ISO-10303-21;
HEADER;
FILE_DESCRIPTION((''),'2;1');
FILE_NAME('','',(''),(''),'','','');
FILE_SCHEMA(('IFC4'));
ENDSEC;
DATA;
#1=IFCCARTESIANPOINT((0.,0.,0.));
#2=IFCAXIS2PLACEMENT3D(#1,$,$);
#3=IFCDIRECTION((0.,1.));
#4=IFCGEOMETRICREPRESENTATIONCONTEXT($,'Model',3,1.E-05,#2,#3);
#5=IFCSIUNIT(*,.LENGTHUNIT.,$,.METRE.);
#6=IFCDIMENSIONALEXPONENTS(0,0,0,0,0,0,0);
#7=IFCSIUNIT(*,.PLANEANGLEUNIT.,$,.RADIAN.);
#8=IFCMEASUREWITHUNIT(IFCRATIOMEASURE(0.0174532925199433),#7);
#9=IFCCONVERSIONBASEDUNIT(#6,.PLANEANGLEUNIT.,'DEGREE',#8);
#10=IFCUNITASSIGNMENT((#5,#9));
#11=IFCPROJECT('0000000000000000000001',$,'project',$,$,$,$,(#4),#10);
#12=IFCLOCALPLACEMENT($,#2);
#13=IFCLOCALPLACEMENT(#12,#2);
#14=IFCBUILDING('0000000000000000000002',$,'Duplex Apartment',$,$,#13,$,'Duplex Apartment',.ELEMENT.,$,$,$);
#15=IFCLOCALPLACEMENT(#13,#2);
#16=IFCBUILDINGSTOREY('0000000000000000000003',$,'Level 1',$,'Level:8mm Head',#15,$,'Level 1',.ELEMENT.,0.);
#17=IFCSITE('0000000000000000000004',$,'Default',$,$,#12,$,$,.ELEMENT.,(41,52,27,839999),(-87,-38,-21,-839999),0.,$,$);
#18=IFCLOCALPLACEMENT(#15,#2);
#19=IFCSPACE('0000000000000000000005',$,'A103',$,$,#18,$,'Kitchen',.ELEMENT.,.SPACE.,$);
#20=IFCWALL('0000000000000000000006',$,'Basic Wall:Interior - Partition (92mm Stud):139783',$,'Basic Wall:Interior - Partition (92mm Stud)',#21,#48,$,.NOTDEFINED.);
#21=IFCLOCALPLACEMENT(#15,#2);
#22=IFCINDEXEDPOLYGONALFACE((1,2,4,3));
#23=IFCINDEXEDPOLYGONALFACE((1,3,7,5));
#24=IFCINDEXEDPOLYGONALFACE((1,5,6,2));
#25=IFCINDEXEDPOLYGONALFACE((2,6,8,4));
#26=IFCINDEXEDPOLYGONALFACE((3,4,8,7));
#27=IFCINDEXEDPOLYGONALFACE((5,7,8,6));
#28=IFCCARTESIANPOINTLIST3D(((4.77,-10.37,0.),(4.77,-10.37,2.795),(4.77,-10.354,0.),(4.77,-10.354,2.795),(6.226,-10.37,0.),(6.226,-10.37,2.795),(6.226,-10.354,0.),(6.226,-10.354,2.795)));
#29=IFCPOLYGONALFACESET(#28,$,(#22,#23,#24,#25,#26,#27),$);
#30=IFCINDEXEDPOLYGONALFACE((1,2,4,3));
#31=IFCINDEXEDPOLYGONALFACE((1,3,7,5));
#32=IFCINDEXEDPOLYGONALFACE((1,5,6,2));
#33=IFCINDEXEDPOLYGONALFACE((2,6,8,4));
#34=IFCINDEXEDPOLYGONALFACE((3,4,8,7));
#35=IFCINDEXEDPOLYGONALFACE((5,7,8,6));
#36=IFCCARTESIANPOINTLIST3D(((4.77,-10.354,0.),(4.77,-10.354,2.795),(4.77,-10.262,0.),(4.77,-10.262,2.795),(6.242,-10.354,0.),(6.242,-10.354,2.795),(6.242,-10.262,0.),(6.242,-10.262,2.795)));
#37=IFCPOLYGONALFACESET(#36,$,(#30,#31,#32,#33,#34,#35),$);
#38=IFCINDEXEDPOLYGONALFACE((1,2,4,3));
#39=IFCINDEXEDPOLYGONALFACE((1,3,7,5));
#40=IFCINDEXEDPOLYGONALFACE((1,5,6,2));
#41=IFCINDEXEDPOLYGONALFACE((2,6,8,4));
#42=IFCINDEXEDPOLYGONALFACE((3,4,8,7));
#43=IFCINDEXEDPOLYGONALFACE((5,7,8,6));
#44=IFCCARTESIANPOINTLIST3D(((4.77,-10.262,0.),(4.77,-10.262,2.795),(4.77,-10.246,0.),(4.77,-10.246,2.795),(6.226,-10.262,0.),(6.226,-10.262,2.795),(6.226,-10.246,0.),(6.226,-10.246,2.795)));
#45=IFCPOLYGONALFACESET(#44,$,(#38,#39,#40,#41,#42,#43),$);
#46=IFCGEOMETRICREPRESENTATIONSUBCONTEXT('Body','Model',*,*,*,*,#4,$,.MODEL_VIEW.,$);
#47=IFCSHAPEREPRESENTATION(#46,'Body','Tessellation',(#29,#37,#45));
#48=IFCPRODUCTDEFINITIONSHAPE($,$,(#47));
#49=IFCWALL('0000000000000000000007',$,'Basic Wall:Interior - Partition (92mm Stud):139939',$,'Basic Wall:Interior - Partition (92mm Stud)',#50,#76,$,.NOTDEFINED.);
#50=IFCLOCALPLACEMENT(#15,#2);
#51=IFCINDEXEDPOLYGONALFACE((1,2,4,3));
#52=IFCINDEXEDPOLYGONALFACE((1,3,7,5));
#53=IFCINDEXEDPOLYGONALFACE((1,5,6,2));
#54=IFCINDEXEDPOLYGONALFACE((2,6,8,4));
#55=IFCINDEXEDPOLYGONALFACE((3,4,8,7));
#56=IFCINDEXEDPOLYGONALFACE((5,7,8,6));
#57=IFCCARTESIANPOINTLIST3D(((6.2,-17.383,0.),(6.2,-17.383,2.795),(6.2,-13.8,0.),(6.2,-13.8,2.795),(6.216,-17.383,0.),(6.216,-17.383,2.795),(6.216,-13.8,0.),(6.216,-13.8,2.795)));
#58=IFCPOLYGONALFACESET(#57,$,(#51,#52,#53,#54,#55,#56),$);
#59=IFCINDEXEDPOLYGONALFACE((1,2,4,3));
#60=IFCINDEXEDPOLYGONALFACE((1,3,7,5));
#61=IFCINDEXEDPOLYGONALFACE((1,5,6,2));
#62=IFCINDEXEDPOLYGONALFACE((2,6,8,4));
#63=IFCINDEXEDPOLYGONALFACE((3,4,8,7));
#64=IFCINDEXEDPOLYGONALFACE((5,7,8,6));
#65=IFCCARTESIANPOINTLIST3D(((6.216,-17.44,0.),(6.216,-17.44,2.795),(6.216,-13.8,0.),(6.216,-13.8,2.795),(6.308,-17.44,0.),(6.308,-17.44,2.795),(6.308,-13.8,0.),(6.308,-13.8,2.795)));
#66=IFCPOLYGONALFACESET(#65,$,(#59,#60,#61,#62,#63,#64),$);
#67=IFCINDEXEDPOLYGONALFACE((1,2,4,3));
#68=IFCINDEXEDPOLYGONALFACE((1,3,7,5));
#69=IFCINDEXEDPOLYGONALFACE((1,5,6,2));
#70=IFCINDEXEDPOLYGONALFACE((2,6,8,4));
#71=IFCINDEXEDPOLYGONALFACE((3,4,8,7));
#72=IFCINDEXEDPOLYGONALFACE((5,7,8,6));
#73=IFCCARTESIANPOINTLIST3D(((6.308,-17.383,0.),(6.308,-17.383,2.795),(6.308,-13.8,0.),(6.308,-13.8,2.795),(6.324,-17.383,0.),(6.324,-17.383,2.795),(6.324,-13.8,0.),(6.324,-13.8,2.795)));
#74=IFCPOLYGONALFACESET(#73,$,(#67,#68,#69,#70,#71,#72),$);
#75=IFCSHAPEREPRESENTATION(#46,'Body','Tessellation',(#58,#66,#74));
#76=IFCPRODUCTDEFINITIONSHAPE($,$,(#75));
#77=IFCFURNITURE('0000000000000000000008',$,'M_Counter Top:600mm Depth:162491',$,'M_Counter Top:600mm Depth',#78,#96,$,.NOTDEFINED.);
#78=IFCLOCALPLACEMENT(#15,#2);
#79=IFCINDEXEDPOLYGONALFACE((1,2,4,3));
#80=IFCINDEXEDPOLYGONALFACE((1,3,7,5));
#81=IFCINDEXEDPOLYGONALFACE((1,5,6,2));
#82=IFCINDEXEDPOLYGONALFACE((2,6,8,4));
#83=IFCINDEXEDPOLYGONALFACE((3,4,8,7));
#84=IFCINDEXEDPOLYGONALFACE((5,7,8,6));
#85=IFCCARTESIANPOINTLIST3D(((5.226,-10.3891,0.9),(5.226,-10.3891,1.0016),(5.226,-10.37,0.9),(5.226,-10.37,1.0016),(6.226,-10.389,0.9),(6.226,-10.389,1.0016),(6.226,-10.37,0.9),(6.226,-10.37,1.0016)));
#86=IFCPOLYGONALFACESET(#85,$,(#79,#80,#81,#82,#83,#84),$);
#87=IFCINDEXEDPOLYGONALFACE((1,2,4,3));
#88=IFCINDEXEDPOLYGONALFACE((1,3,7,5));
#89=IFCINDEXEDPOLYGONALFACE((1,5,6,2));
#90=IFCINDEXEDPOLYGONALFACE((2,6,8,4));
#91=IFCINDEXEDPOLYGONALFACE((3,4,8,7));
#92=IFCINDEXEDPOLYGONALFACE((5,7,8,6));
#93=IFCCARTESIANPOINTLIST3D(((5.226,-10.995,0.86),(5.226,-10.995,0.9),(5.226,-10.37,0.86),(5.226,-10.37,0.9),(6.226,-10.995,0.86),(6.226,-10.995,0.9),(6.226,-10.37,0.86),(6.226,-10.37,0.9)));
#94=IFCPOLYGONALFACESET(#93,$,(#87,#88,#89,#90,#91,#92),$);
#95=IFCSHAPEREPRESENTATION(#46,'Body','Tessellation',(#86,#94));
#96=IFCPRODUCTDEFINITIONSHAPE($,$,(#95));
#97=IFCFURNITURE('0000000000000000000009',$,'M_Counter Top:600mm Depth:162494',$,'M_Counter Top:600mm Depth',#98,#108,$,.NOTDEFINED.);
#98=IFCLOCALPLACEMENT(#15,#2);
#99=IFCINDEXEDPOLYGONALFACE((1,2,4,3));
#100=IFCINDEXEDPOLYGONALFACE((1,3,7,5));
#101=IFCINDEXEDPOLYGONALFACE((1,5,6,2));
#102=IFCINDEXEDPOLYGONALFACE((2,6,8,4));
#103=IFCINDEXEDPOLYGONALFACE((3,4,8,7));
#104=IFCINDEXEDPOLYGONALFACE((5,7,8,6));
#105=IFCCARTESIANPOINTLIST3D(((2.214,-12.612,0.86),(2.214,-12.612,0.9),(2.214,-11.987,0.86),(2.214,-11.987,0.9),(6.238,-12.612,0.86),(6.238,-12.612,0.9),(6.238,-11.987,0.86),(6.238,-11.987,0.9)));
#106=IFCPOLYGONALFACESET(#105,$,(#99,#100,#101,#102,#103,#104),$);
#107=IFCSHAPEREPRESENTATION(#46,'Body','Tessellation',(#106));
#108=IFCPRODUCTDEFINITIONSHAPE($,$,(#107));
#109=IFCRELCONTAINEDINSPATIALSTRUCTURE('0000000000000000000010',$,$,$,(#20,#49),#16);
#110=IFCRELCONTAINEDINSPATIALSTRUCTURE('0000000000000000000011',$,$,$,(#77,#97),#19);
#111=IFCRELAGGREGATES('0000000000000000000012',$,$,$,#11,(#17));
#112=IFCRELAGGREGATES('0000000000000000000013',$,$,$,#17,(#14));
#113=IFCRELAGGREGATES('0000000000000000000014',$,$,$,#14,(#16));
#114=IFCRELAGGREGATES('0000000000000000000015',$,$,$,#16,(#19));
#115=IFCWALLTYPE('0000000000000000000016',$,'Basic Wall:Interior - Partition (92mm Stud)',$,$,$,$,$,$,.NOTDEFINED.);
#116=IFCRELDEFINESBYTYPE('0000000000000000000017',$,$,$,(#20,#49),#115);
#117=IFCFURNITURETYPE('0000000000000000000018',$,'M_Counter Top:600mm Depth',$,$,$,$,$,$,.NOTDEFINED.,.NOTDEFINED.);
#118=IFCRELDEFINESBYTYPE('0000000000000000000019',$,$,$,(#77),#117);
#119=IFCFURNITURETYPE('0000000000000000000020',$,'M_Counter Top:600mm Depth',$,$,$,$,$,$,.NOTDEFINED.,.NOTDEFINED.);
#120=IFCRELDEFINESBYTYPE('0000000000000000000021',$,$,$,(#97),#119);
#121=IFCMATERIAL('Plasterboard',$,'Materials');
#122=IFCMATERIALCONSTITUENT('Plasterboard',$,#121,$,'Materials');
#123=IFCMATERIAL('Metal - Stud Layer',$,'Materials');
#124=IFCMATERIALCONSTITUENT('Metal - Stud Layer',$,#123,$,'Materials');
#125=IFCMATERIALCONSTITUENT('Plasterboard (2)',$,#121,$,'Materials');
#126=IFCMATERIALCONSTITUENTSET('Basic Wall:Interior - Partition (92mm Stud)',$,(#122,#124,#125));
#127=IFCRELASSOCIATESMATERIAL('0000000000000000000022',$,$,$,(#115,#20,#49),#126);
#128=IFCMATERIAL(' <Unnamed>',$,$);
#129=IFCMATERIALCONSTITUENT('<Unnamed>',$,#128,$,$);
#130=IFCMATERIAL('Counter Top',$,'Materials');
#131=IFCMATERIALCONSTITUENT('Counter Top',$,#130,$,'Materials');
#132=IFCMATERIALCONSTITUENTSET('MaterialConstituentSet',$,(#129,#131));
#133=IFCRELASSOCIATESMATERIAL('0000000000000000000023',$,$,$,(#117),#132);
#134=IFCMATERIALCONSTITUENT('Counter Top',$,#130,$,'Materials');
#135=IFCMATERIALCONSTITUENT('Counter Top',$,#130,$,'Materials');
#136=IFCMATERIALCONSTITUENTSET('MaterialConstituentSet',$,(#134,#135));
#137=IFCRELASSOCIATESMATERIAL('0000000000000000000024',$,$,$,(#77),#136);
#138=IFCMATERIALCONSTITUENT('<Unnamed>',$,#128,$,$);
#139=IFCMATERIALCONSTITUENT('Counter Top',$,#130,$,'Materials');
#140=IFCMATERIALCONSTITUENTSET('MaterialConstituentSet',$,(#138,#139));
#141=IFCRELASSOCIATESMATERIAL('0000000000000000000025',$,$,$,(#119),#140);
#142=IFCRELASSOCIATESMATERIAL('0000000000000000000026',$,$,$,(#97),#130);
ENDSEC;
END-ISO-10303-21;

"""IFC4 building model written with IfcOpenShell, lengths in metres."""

from ifc_helpers import new_model, entity, si_unit, converted_unit, direction, frame, origin, place, context, subcontext, project, spatial, indexed_curve, outline, extrude, source, transform, mapped, material, constituent, constituent_set, type_object, type_shapes, element, save


model = new_model("IFC4")

# Units and contexts
model_context = context("Model", 3, precision=1e-05, world=origin(), true_north=direction((0.0, 1.0)))
body_context = subcontext(model_context, "Body", "Model", "MODEL_VIEW")
ifc_project = project(units=[si_unit("LENGTHUNIT", "METRE"), converted_unit("PLANEANGLEUNIT", "DEGREE", entity("IfcRatioMeasure", 0.0174532925199433), si_unit("PLANEANGLEUNIT", "RADIAN"), dimensions=[0, 0, 0, 0, 0, 0, 0])], contexts=[model_context])

# Site, building, storey
site_placement = place(None, origin())
site = spatial("IfcSite", under=ifc_project, at=site_placement, Name="Default", CompositionType="ELEMENT", RefLatitude=(41, 52, 27, 839999), RefLongitude=(-87, -38, -21, -839999), RefElevation=0.0)
building_placement = place(site_placement, origin())
building = spatial("IfcBuilding", under=site, at=building_placement, Name="Duplex Apartment", LongName="Duplex Apartment", CompositionType="ELEMENT")
storey_placement = place(building_placement, origin())
storey = spatial("IfcBuildingStorey", under=building, at=storey_placement, Name="Level 1", ObjectType="Level:8mm Head", LongName="Level 1", CompositionType="ELEMENT", Elevation=0.0)

# Shared definitions
ifc_material_1 = material(Name="Metal - Stud Layer", Category="Materials")
ifc_material_2 = material(Name="Plasterboard", Category="Materials")

# Shared definitions
ifc_constituent_1 = constituent(ifc_material_2, Name="Plasterboard", Category="Materials")
ifc_constituent_2 = constituent(ifc_material_1, Name="Metal - Stud Layer", Category="Materials")
ifc_constituent_3 = constituent(ifc_material_2, Name="Plasterboard (2)", Category="Materials")
ifc_constituent_set_1 = constituent_set(constituents=[ifc_constituent_1, ifc_constituent_2, ifc_constituent_3], Name="Basic Wall:Interior - Partition (92mm Stud)")
wall_type_1 = type_object("IfcWallType", Name="Basic Wall:Interior - Partition (92mm Stud)", PredefinedType="NOTDEFINED", material=ifc_constituent_set_1)

# Walls
wall_1_placement = place(storey_placement, frame((4.77, -10.308, 0.0)))
element("IfcWall", 1, at=wall_1_placement, inside=storey, type_object=wall_type_1, material=ifc_constituent_set_1, Name="Basic Wall:Interior - Partition (92mm Stud):139783", ObjectType="Basic Wall:Interior - Partition (92mm Stud)", PredefinedType="NOTDEFINED", context=body_context, shape_type="SweptSolid", body=[
    extrude(outline(indexed_curve([(-0.008, -0.728), (0.008, -0.728), (0.008, 0.728), (-0.008, 0.728), (-0.008, -0.728)], self_intersect=False)), frame((0.728, -0.054, 0.0), z_axis=(0.0, 0.0, 1.0), x_axis=(0.0, 1.0, 0.0)), (0.0, 0.0, 1.0), 2.795),
    extrude(outline(indexed_curve([(-0.736, -0.046), (0.736, -0.046), (0.736, 0.046), (-0.736, 0.046), (-0.736, -0.046)], self_intersect=False)), frame((0.736, 0.0, 0.0)), (0.0, 0.0, 1.0), 2.795),
    extrude(outline(indexed_curve([(-0.008, -0.728), (0.008, -0.728), (0.008, 0.728), (-0.008, 0.728), (-0.008, -0.728)], self_intersect=False)), frame((0.728, 0.054, 0.0), z_axis=(0.0, 0.0, 1.0), x_axis=(0.0, -1.0, 0.0)), (0.0, 0.0, 1.0), 2.795),
])
wall_2_placement = place(storey_placement, frame((6.262, -13.8, 0.0), z_axis=(0.0, 0.0, 1.0), x_axis=(0.0, -1.0, 0.0)))
element("IfcWall", 2, at=wall_2_placement, inside=storey, type_object=wall_type_1, material=ifc_constituent_set_1, Name="Basic Wall:Interior - Partition (92mm Stud):139939", ObjectType="Basic Wall:Interior - Partition (92mm Stud)", PredefinedType="NOTDEFINED", context=body_context, shape_type="SweptSolid", body=[
    extrude(outline(indexed_curve([(-0.008, -1.7915), (0.008, -1.7915), (0.008, 1.7915), (-0.008, 1.7915), (-0.008, -1.7915)], self_intersect=False)), frame((1.7915, -0.054, 0.0), z_axis=(0.0, 0.0, 1.0), x_axis=(0.0, 1.0, 0.0)), (0.0, 0.0, 1.0), 2.795),
    extrude(outline(indexed_curve([(-1.82, -0.046), (1.82, -0.046), (1.82, 0.046), (-1.82, 0.046), (-1.82, -0.046)], self_intersect=False)), frame((1.82, 0.0, 0.0)), (0.0, 0.0, 1.0), 2.795),
    extrude(outline(indexed_curve([(-0.008, -1.7915), (0.008, -1.7915), (0.008, 1.7915), (-0.008, 1.7915), (-0.008, -1.7915)], self_intersect=False)), frame((1.7915, 0.054, 0.0), z_axis=(0.0, 0.0, 1.0), x_axis=(0.0, -1.0, 0.0)), (0.0, 0.0, 1.0), 2.795),
])

# Shared definitions
space_1_placement = place(storey_placement, origin())
space_1 = spatial("IfcSpace", under=storey, at=space_1_placement, Name="A103", LongName="Kitchen", CompositionType="ELEMENT", PredefinedType="SPACE")

# Furniture
ifc_material_3 = material(Name="Counter Top", Category="Materials")
ifc_constituent_4 = constituent(ifc_material_3, Name="Counter Top", Category="Materials")
ifc_constituent_5 = constituent(ifc_material_3, Name="Counter Top", Category="Materials")
ifc_constituent_set_2 = constituent_set(constituents=[ifc_constituent_4, ifc_constituent_5], Name="MaterialConstituentSet")
ifc_material_4 = material(Name=" <Unnamed>")
ifc_constituent_6 = constituent(ifc_material_4, Name="<Unnamed>")
ifc_constituent_7 = constituent(ifc_material_3, Name="Counter Top", Category="Materials")
ifc_constituent_set_3 = constituent_set(constituents=[ifc_constituent_6, ifc_constituent_7], Name="MaterialConstituentSet")
furniture_type_1 = type_object("IfcFurnitureType", Name="M_Counter Top:600mm Depth", AssemblyPlace="NOTDEFINED", PredefinedType="NOTDEFINED", material=ifc_constituent_set_3)
shared_shape_1 = source(origin(), body_context, "Body", "SweptSolid", [
    extrude(outline(indexed_curve([(-0.0095, -0.5), (0.0095, -0.5), (0.0095, 0.5), (-0.0095, 0.5), (-0.0095, -0.5)], self_intersect=False)), frame((-0.7005, -0.0095, 0.9), z_axis=(0.0, 0.0, 1.0), x_axis=(0.0, -1.0, 0.0)), (0.0, 0.0, 1.0), 0.1016),
    extrude(outline(indexed_curve([(-0.5, -0.3125), (0.5, -0.3125), (0.5, 0.3125), (-0.5, 0.3125), (-0.5, -0.3125)], self_intersect=False)), frame((-0.7005, -0.3125, 0.86), z_axis=(0.0, 0.0, 1.0), x_axis=(-1.0, 0.0, 0.0)), (0.0, 0.0, 1.0), 0.04),
])
type_shapes(furniture_type_1, [shared_shape_1])
furniture_1_placement = place(space_1_placement, frame((6.4265, -10.37, 0.0)))
element("IfcFurniture", 3, at=furniture_1_placement, inside=space_1, type_object=furniture_type_1, material=ifc_constituent_set_2, Name="M_Counter Top:600mm Depth:162491", ObjectType="M_Counter Top:600mm Depth", PredefinedType="NOTDEFINED", context=body_context, shape_type="MappedRepresentation", body=[
    mapped(shared_shape_1, transform((0.0, 0.0, 0.0), scale=1.0)),
])
ifc_constituent_8 = constituent(ifc_material_4, Name="<Unnamed>")
ifc_constituent_9 = constituent(ifc_material_3, Name="Counter Top", Category="Materials")
ifc_constituent_set_4 = constituent_set(constituents=[ifc_constituent_8, ifc_constituent_9], Name="MaterialConstituentSet")
furniture_type_2 = type_object("IfcFurnitureType", Name="M_Counter Top:600mm Depth", AssemblyPlace="NOTDEFINED", PredefinedType="NOTDEFINED", material=ifc_constituent_set_4)
shared_shape_2 = source(origin(), body_context, "Body", "SweptSolid", [
    extrude(outline(indexed_curve([(-2.012, -0.3125), (2.012, -0.3125), (2.012, 0.3125), (-2.012, 0.3125), (-2.012, -0.3125)], self_intersect=False)), frame((0.8115, -0.3125, 0.86), z_axis=(0.0, 0.0, 1.0), x_axis=(-1.0, 0.0, 0.0)), (0.0, 0.0, 1.0), 0.04),
])
type_shapes(furniture_type_2, [shared_shape_2])
furniture_2_placement = place(space_1_placement, frame((5.0375, -12.612, 0.0), z_axis=(0.0, 0.0, 1.0), x_axis=(-1.0, 0.0, 0.0)))
element("IfcFurniture", 4, at=furniture_2_placement, inside=space_1, type_object=furniture_type_2, material=ifc_material_3, Name="M_Counter Top:600mm Depth:162494", ObjectType="M_Counter Top:600mm Depth", PredefinedType="NOTDEFINED", context=body_context, shape_type="MappedRepresentation", body=[
    mapped(shared_shape_2, transform((0.0, 0.0, 0.0), scale=1.0)),
])

save(model, "model.ifc")
